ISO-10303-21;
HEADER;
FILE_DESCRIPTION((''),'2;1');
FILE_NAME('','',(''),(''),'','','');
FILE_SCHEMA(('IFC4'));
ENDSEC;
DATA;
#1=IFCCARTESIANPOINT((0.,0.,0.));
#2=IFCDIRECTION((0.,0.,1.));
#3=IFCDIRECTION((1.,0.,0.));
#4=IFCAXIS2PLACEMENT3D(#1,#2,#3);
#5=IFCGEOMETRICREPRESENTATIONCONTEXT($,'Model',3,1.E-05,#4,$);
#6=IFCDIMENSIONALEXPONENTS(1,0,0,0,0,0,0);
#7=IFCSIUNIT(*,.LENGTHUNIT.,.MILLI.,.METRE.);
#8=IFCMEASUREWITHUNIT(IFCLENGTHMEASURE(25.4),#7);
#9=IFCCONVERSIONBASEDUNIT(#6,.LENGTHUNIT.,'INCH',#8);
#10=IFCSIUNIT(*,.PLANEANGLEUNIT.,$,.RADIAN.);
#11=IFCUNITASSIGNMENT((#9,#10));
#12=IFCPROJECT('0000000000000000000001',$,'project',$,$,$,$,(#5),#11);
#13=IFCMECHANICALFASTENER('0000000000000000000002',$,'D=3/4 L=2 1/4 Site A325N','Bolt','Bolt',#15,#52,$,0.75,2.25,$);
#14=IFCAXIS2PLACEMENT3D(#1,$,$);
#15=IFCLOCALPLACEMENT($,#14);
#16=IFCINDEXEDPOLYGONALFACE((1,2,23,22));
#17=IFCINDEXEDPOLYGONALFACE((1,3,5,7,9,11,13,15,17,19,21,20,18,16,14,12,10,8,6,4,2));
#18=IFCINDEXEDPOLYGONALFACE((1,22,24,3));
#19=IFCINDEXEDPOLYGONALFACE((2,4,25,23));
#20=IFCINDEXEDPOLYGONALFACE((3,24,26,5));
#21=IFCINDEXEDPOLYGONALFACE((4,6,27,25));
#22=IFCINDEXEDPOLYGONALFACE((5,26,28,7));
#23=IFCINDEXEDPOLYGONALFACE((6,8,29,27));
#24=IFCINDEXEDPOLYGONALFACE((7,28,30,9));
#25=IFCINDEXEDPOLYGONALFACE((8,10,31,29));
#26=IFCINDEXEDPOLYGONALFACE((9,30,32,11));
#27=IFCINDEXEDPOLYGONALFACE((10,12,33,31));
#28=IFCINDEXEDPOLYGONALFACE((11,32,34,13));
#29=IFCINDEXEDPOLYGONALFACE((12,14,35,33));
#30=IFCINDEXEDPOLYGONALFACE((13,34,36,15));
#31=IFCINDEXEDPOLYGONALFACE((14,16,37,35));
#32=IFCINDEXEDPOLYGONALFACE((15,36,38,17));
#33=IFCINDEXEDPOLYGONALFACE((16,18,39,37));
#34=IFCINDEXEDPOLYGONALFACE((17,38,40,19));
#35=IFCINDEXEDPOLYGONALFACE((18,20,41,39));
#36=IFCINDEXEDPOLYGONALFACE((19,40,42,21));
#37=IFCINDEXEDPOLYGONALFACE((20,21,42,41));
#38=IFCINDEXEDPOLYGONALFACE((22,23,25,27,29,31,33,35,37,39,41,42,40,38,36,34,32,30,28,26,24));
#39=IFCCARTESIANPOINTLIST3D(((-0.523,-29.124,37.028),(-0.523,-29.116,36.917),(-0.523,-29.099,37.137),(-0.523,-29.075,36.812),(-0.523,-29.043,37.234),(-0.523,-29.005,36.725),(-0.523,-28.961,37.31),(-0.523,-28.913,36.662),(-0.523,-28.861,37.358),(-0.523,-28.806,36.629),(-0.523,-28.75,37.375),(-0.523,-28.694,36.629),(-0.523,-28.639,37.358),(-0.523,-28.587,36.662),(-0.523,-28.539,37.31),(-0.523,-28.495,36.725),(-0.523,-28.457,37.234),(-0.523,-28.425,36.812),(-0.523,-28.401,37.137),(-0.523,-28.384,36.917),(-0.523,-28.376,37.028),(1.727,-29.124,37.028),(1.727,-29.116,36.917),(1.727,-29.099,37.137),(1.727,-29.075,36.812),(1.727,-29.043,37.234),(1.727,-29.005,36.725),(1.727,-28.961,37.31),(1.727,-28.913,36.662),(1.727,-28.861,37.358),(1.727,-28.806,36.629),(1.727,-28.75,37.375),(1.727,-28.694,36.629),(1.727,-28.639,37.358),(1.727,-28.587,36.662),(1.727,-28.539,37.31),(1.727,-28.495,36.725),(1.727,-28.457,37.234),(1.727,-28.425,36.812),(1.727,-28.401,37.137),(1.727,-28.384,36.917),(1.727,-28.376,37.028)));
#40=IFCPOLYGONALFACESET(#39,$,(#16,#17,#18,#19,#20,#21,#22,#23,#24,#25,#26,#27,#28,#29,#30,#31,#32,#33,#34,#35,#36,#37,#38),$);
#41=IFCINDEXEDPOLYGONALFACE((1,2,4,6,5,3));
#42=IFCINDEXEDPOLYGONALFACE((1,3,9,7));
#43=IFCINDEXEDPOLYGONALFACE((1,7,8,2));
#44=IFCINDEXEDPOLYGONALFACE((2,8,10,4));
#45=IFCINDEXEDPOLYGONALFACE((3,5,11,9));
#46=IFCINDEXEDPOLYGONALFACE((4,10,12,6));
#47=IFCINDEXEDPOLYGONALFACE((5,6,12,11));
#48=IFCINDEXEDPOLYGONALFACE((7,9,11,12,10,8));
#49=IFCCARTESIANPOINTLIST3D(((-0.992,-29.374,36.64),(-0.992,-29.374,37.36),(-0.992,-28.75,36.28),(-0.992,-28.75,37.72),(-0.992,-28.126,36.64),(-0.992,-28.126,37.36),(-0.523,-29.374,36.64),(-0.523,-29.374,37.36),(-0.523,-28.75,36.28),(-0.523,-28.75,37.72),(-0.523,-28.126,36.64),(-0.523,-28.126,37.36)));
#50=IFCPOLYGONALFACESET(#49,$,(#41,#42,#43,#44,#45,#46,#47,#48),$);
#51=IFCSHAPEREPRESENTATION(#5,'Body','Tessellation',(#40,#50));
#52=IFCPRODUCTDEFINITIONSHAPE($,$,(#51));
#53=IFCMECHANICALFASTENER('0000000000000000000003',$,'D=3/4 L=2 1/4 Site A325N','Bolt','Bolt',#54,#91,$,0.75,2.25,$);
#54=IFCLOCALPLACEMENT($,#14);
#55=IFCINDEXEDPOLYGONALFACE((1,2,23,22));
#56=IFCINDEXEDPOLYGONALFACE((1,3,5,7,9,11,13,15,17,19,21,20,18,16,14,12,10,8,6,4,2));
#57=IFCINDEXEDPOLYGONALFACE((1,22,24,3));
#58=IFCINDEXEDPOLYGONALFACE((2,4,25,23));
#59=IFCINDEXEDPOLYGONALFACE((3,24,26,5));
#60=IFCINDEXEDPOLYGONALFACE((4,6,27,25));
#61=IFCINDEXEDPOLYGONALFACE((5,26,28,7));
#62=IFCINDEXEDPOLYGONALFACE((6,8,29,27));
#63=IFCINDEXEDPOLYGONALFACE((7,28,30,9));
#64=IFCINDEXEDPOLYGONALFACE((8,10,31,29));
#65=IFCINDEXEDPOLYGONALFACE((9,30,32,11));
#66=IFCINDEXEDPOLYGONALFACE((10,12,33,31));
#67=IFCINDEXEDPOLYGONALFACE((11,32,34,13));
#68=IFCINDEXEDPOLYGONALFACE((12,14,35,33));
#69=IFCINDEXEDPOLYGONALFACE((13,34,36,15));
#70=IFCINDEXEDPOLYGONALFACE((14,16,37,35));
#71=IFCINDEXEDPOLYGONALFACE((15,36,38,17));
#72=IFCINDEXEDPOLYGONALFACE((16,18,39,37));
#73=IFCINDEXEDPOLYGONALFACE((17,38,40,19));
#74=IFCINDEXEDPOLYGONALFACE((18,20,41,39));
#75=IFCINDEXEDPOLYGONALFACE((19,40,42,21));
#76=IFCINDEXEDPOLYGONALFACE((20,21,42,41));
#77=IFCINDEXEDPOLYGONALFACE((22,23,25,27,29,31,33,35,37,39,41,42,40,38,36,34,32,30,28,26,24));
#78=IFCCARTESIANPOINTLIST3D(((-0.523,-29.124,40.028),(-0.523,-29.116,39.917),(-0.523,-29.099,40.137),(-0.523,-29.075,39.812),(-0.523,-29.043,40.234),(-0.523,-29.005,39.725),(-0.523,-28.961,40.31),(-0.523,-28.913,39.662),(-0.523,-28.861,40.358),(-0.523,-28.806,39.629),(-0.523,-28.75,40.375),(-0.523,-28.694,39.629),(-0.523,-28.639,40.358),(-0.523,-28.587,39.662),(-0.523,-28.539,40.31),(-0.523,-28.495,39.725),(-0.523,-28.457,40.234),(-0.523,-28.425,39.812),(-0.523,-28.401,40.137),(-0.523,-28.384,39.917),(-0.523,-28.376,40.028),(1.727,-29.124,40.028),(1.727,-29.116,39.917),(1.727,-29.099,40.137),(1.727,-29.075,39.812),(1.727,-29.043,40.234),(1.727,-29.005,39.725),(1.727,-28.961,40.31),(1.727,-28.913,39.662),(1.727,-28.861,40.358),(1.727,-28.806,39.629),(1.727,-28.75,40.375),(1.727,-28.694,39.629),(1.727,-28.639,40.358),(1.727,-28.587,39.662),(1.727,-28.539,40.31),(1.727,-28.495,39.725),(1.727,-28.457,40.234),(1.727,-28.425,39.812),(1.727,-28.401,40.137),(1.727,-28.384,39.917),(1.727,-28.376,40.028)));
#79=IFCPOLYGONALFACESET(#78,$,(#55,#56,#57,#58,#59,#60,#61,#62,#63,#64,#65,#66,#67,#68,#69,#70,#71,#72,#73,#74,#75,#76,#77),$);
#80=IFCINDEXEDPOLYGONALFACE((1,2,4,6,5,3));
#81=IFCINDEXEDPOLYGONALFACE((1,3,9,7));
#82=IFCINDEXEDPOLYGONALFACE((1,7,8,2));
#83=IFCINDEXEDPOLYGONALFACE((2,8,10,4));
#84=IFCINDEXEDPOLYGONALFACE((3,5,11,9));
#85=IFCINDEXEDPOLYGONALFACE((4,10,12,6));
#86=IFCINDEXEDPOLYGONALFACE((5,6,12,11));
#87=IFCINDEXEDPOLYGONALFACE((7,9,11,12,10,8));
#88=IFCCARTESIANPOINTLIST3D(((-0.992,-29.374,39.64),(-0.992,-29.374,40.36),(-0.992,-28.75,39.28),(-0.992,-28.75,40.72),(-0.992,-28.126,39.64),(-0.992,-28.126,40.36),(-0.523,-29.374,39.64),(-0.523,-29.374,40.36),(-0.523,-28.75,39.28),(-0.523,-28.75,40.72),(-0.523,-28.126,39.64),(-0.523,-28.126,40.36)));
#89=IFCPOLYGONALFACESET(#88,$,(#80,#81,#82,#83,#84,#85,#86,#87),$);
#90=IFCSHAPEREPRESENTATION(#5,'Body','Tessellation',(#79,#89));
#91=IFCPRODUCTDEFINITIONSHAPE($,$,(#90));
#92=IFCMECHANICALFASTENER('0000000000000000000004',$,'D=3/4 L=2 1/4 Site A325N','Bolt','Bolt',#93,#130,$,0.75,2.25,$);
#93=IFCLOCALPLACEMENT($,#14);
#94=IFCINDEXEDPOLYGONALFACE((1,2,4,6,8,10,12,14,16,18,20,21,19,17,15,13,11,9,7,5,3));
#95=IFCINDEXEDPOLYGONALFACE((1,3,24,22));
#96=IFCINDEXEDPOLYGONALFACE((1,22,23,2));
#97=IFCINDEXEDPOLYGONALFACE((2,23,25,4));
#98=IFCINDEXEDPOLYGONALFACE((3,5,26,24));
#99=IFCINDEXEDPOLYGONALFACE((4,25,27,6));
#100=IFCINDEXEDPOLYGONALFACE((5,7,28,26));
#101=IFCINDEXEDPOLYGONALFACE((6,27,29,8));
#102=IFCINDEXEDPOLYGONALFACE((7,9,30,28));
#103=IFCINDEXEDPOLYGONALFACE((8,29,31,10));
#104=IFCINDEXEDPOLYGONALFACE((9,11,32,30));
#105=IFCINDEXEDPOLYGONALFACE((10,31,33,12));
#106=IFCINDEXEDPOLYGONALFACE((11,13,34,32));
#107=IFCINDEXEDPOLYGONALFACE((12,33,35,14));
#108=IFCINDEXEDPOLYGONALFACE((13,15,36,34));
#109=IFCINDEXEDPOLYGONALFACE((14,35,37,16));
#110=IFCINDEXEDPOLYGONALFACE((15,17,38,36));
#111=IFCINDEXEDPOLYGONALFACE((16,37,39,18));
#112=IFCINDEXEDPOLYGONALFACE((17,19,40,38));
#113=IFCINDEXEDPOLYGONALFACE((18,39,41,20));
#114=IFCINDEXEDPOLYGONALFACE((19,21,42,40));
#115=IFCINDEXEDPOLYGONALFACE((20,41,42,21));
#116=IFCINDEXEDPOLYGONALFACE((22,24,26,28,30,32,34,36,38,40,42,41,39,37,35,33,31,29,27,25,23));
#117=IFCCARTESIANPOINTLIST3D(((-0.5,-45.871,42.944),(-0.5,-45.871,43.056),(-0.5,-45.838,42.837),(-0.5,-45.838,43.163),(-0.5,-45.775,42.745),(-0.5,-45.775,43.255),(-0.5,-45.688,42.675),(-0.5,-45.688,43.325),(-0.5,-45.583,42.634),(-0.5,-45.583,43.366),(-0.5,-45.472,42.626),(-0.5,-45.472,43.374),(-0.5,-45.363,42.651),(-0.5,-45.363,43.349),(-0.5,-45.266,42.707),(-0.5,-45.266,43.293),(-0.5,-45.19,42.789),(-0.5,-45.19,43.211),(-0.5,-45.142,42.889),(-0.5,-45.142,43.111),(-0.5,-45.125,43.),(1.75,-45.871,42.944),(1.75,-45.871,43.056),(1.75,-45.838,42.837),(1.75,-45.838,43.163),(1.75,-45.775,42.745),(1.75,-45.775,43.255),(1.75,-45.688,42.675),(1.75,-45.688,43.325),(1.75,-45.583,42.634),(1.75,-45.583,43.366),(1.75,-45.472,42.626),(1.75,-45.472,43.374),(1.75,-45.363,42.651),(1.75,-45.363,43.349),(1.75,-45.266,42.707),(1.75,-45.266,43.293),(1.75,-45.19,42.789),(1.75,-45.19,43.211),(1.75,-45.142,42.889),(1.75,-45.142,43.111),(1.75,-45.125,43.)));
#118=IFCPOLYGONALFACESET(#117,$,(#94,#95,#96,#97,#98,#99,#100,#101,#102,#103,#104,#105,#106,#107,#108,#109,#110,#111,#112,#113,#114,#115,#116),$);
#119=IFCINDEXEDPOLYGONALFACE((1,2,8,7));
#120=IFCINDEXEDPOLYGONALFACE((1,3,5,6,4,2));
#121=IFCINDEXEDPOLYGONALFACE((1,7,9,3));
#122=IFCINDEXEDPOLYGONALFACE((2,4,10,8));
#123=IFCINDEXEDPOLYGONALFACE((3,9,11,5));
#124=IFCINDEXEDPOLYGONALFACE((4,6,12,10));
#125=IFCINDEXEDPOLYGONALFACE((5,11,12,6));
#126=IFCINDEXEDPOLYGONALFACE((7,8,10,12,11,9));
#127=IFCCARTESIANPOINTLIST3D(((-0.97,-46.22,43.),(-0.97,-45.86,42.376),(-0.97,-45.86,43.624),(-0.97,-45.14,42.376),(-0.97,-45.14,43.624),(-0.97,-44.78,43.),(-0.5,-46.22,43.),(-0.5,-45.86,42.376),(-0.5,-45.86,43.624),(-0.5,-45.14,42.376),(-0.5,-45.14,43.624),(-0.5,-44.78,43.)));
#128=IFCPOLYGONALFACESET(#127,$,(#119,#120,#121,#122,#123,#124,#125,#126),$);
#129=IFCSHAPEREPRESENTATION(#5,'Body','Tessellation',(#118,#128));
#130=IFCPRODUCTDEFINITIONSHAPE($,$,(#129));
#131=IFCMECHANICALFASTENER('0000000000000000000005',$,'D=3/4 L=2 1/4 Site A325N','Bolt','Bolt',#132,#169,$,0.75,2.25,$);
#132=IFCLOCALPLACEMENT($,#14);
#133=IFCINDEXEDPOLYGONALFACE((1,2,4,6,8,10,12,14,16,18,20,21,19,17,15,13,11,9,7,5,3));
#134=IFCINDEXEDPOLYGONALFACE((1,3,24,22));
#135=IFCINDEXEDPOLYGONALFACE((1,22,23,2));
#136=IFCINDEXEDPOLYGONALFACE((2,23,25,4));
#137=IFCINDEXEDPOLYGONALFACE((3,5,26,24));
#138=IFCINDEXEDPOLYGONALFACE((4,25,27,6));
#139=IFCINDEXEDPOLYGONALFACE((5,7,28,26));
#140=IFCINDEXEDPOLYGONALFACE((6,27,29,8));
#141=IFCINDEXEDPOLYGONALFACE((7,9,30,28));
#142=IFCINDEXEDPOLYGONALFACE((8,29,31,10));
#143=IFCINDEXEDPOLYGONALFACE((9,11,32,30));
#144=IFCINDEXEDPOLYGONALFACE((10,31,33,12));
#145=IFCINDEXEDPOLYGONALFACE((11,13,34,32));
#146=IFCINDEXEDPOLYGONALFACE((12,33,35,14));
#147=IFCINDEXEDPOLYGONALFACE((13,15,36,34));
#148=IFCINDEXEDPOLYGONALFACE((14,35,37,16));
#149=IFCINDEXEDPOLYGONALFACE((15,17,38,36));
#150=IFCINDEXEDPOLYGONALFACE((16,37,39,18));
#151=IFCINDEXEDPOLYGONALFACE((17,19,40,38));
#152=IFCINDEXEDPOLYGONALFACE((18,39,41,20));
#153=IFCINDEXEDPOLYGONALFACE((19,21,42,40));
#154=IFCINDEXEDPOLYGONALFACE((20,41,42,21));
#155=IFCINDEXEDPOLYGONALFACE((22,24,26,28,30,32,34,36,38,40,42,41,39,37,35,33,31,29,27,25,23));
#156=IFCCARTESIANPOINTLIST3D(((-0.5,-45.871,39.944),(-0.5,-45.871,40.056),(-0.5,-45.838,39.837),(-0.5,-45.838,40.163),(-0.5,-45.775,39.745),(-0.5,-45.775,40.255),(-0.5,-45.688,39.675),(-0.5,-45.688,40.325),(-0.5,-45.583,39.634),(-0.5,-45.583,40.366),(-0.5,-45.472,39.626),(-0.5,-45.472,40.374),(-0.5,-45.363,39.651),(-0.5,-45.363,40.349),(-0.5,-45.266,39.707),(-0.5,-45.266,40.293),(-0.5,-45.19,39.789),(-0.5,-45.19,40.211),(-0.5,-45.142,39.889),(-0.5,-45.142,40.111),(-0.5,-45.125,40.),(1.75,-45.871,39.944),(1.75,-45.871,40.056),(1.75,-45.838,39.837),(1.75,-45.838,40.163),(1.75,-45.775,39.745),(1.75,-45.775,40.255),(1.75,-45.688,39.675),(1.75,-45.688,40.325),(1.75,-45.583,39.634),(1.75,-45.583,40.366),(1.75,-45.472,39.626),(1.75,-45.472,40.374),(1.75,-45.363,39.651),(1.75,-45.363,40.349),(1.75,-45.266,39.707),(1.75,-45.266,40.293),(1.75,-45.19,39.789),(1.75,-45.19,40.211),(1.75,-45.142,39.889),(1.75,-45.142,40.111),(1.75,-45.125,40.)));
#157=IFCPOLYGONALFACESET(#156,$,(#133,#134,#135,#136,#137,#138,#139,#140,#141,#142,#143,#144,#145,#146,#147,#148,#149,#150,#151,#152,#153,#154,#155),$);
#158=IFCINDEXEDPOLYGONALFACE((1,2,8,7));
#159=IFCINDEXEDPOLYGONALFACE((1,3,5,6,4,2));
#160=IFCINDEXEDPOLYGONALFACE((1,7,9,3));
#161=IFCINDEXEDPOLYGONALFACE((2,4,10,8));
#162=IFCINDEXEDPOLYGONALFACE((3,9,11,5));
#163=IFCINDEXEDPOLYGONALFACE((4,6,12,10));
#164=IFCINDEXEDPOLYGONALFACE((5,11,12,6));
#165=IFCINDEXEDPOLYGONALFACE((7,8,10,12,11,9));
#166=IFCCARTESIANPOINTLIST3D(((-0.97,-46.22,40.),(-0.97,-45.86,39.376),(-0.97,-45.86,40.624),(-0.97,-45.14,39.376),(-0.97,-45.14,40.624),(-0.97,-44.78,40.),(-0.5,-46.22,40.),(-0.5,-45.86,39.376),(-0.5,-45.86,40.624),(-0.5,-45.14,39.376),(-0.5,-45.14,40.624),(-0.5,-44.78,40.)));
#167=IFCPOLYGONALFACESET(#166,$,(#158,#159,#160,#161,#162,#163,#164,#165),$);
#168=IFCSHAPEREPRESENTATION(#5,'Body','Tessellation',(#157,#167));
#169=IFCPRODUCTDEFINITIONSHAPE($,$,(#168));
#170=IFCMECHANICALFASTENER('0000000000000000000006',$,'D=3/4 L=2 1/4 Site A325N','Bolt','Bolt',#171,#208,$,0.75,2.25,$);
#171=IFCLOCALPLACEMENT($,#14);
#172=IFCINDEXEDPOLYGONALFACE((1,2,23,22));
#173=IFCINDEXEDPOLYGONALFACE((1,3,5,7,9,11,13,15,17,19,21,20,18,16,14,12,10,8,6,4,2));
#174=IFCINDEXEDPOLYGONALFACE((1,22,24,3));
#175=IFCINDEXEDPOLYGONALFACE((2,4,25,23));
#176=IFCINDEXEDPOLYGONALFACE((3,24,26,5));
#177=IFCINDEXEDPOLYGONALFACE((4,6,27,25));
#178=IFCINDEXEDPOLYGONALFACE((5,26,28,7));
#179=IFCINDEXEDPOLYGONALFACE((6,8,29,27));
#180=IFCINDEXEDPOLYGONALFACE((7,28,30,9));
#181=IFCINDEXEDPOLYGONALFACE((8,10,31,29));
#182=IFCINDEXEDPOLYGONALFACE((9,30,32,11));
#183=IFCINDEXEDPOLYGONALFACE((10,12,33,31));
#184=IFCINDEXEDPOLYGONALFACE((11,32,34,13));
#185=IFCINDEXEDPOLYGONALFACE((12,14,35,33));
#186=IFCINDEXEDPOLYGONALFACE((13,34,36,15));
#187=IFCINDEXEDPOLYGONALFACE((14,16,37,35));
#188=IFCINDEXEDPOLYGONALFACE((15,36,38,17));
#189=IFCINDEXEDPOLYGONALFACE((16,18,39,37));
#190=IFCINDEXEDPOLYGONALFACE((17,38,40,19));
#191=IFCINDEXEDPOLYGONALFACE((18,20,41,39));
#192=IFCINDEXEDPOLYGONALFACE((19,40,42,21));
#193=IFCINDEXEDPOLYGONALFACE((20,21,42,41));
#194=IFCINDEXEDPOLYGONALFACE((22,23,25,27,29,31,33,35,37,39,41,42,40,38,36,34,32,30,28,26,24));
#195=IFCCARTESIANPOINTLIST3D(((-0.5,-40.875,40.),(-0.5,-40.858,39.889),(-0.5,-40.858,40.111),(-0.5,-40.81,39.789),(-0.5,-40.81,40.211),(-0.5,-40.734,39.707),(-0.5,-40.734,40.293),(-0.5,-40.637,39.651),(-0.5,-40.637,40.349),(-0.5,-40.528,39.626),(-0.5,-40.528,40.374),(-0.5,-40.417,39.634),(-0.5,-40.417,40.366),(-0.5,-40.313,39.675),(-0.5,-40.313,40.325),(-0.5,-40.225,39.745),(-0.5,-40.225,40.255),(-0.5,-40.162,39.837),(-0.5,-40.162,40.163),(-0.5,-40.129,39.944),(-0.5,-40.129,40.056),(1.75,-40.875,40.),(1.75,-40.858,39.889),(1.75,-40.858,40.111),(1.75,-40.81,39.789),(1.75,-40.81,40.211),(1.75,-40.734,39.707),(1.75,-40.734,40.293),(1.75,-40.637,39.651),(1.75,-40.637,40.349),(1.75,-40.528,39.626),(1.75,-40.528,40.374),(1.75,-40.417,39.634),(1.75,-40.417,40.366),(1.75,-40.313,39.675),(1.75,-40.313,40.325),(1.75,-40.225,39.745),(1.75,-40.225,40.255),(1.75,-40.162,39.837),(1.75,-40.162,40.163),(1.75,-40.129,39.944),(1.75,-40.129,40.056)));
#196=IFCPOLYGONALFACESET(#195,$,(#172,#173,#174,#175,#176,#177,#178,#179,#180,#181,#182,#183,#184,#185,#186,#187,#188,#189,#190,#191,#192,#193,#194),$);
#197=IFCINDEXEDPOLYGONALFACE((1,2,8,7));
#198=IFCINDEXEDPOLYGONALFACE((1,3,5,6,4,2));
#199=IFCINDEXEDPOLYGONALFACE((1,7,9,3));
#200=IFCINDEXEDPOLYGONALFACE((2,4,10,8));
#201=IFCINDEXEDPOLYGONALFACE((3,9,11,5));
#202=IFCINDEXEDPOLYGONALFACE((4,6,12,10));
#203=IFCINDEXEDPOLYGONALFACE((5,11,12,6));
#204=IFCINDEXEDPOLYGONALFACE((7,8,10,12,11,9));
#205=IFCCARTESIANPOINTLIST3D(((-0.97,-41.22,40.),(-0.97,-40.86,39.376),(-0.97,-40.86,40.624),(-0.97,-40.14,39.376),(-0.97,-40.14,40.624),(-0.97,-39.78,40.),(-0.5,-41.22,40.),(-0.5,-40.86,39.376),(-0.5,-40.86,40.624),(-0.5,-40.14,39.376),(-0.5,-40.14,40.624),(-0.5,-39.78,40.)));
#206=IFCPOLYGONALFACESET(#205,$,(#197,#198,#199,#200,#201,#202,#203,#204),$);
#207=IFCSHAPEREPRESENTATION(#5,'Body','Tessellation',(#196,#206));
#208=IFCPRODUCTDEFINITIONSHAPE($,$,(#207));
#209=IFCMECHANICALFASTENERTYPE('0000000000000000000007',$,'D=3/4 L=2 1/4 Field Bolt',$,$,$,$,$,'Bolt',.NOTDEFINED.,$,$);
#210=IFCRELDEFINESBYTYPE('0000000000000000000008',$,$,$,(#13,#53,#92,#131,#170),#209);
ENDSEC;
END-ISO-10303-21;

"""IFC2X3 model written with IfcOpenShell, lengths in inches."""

from ifc_helpers import new_model, entity, si_unit, converted_unit, frame, origin_with_axes, origin_2d_with_axis, place, context, project, polyline, circle, outline, extrude, source, transform, mapped, type_object, type_shapes, element, save


model = new_model("IFC2X3")

# Units and contexts
model_context = context("Model", 3, precision=1e-05, world=origin_with_axes())
ifc_project = project(units=[converted_unit("LENGTHUNIT", "INCH", entity("IfcLengthMeasure", 25.4), si_unit("LENGTHUNIT", "METRE", prefix="MILLI"), dimensions=[1, 0, 0, 0, 0, 0, 0]), si_unit("PLANEANGLEUNIT", "RADIAN")], contexts=[model_context])

# Mechanical fasteners
placement_1 = place(None, origin_with_axes())
placement_2 = place(placement_1, origin_with_axes())
mechanical_fastener_type_1 = type_object("IfcMechanicalFastenerType", Name="D=3/4 L=2 1/4 Field Bolt", ElementType="Bolt")
shared_shape_1 = source(origin_with_axes(), model_context, "Body", "SweptSolid", [
    extrude(circle(Radius=0.375, at=origin_2d_with_axis()), frame((0.0, 0.0, 0.0), z_axis=(1.0, 0.0, 0.0), x_axis=(0.0, 1.0, 0.0)), (0.0, 0.0, 1.0), 2.25),
    extrude(outline(polyline([(-0.72, 0.0), (-0.36, 0.624), (0.36, 0.624), (0.72, 0.0), (0.36, -0.624), (-0.36, -0.624), (-0.72, 0.0)])), frame((0.0, 0.0, 0.0), z_axis=(1.0, 0.0, 0.0), x_axis=(0.0, 1.0, 0.0)), (0.0, 0.0, -1.0), 0.47),
])
type_shapes(mechanical_fastener_type_1, [shared_shape_1])
placement_3 = place(placement_2, frame((0.0, -27.0, 46.0), z_axis=(0.0, 0.0, 1.0), x_axis=(0.0, -1.0, 0.0)))
placement_4 = place(placement_3, frame((1.75, -0.523, -3.0), z_axis=(1.0, 0.0, 0.0), x_axis=(0.0, 1.0, 0.0)))
for number, where, z_axis, x_axis, name in (
    (1, (0.0, -6.0, 0.0), (0.0, 0.0, 1.0), (1.0, 0.0, 0.0), "D=3/4 L=2 1/4 Site A325N"),
    (2, (0.0, -3.0, 0.0), (0.0, 0.0, 1.0), (1.0, 0.0, 0.0), "D=3/4 L=2 1/4 Site A325N"),
):
    element("IfcMechanicalFastener", number, at=place(placement_4, frame(where, z_axis=z_axis, x_axis=x_axis)), type_object=mechanical_fastener_type_1, Name=name, Description="Bolt", ObjectType="Bolt", NominalDiameter=0.75, NominalLength=2.25, context=model_context, shape_type="MappedRepresentation", body=[
        mapped(shared_shape_1, transform((0.0, 0.0, 0.0), scale=1.0)),
    ])
placement_5 = place(placement_2, frame((0.0, -43.0, 46.0), z_axis=(0.0, 0.0, 1.0), x_axis=(1.0, 0.0, 0.0)))
placement_6 = place(placement_5, frame((-0.5, -2.5, -6.0), z_axis=(0.0, 0.0, 1.0), x_axis=(1.0, 0.0, 0.0)))
for number, where, z_axis, x_axis, name in (
    (3, (0.0, 0.0, 3.0), (0.0, 0.0, 1.0), (1.0, 0.0, 0.0), "D=3/4 L=2 1/4 Site A325N"),
    (4, (0.0, 0.0, 0.0), (0.0, 0.0, 1.0), (1.0, 0.0, 0.0), "D=3/4 L=2 1/4 Site A325N"),
):
    element("IfcMechanicalFastener", number, at=place(placement_6, frame(where, z_axis=z_axis, x_axis=x_axis)), type_object=mechanical_fastener_type_1, Name=name, Description="Bolt", ObjectType="Bolt", NominalDiameter=0.75, NominalLength=2.25, context=model_context, shape_type="MappedRepresentation", body=[
        mapped(shared_shape_1, transform((0.0, 0.0, 0.0), scale=1.0)),
    ])
placement_7 = place(placement_5, frame((-0.5, 2.5, -3.0), z_axis=(0.0, 0.0, -1.0), x_axis=(1.0, 0.0, 0.0)))
for number, where, z_axis, x_axis, name in (
    (5, (0.0, 0.0, 3.0), (0.0, 0.0, 1.0), (1.0, 0.0, 0.0), "D=3/4 L=2 1/4 Site A325N"),
):
    element("IfcMechanicalFastener", number, at=place(placement_7, frame(where, z_axis=z_axis, x_axis=x_axis)), type_object=mechanical_fastener_type_1, Name=name, Description="Bolt", ObjectType="Bolt", NominalDiameter=0.75, NominalLength=2.25, context=model_context, shape_type="MappedRepresentation", body=[
        mapped(shared_shape_1, transform((0.0, 0.0, 0.0), scale=1.0)),
    ])

save(model, "model.ifc")
